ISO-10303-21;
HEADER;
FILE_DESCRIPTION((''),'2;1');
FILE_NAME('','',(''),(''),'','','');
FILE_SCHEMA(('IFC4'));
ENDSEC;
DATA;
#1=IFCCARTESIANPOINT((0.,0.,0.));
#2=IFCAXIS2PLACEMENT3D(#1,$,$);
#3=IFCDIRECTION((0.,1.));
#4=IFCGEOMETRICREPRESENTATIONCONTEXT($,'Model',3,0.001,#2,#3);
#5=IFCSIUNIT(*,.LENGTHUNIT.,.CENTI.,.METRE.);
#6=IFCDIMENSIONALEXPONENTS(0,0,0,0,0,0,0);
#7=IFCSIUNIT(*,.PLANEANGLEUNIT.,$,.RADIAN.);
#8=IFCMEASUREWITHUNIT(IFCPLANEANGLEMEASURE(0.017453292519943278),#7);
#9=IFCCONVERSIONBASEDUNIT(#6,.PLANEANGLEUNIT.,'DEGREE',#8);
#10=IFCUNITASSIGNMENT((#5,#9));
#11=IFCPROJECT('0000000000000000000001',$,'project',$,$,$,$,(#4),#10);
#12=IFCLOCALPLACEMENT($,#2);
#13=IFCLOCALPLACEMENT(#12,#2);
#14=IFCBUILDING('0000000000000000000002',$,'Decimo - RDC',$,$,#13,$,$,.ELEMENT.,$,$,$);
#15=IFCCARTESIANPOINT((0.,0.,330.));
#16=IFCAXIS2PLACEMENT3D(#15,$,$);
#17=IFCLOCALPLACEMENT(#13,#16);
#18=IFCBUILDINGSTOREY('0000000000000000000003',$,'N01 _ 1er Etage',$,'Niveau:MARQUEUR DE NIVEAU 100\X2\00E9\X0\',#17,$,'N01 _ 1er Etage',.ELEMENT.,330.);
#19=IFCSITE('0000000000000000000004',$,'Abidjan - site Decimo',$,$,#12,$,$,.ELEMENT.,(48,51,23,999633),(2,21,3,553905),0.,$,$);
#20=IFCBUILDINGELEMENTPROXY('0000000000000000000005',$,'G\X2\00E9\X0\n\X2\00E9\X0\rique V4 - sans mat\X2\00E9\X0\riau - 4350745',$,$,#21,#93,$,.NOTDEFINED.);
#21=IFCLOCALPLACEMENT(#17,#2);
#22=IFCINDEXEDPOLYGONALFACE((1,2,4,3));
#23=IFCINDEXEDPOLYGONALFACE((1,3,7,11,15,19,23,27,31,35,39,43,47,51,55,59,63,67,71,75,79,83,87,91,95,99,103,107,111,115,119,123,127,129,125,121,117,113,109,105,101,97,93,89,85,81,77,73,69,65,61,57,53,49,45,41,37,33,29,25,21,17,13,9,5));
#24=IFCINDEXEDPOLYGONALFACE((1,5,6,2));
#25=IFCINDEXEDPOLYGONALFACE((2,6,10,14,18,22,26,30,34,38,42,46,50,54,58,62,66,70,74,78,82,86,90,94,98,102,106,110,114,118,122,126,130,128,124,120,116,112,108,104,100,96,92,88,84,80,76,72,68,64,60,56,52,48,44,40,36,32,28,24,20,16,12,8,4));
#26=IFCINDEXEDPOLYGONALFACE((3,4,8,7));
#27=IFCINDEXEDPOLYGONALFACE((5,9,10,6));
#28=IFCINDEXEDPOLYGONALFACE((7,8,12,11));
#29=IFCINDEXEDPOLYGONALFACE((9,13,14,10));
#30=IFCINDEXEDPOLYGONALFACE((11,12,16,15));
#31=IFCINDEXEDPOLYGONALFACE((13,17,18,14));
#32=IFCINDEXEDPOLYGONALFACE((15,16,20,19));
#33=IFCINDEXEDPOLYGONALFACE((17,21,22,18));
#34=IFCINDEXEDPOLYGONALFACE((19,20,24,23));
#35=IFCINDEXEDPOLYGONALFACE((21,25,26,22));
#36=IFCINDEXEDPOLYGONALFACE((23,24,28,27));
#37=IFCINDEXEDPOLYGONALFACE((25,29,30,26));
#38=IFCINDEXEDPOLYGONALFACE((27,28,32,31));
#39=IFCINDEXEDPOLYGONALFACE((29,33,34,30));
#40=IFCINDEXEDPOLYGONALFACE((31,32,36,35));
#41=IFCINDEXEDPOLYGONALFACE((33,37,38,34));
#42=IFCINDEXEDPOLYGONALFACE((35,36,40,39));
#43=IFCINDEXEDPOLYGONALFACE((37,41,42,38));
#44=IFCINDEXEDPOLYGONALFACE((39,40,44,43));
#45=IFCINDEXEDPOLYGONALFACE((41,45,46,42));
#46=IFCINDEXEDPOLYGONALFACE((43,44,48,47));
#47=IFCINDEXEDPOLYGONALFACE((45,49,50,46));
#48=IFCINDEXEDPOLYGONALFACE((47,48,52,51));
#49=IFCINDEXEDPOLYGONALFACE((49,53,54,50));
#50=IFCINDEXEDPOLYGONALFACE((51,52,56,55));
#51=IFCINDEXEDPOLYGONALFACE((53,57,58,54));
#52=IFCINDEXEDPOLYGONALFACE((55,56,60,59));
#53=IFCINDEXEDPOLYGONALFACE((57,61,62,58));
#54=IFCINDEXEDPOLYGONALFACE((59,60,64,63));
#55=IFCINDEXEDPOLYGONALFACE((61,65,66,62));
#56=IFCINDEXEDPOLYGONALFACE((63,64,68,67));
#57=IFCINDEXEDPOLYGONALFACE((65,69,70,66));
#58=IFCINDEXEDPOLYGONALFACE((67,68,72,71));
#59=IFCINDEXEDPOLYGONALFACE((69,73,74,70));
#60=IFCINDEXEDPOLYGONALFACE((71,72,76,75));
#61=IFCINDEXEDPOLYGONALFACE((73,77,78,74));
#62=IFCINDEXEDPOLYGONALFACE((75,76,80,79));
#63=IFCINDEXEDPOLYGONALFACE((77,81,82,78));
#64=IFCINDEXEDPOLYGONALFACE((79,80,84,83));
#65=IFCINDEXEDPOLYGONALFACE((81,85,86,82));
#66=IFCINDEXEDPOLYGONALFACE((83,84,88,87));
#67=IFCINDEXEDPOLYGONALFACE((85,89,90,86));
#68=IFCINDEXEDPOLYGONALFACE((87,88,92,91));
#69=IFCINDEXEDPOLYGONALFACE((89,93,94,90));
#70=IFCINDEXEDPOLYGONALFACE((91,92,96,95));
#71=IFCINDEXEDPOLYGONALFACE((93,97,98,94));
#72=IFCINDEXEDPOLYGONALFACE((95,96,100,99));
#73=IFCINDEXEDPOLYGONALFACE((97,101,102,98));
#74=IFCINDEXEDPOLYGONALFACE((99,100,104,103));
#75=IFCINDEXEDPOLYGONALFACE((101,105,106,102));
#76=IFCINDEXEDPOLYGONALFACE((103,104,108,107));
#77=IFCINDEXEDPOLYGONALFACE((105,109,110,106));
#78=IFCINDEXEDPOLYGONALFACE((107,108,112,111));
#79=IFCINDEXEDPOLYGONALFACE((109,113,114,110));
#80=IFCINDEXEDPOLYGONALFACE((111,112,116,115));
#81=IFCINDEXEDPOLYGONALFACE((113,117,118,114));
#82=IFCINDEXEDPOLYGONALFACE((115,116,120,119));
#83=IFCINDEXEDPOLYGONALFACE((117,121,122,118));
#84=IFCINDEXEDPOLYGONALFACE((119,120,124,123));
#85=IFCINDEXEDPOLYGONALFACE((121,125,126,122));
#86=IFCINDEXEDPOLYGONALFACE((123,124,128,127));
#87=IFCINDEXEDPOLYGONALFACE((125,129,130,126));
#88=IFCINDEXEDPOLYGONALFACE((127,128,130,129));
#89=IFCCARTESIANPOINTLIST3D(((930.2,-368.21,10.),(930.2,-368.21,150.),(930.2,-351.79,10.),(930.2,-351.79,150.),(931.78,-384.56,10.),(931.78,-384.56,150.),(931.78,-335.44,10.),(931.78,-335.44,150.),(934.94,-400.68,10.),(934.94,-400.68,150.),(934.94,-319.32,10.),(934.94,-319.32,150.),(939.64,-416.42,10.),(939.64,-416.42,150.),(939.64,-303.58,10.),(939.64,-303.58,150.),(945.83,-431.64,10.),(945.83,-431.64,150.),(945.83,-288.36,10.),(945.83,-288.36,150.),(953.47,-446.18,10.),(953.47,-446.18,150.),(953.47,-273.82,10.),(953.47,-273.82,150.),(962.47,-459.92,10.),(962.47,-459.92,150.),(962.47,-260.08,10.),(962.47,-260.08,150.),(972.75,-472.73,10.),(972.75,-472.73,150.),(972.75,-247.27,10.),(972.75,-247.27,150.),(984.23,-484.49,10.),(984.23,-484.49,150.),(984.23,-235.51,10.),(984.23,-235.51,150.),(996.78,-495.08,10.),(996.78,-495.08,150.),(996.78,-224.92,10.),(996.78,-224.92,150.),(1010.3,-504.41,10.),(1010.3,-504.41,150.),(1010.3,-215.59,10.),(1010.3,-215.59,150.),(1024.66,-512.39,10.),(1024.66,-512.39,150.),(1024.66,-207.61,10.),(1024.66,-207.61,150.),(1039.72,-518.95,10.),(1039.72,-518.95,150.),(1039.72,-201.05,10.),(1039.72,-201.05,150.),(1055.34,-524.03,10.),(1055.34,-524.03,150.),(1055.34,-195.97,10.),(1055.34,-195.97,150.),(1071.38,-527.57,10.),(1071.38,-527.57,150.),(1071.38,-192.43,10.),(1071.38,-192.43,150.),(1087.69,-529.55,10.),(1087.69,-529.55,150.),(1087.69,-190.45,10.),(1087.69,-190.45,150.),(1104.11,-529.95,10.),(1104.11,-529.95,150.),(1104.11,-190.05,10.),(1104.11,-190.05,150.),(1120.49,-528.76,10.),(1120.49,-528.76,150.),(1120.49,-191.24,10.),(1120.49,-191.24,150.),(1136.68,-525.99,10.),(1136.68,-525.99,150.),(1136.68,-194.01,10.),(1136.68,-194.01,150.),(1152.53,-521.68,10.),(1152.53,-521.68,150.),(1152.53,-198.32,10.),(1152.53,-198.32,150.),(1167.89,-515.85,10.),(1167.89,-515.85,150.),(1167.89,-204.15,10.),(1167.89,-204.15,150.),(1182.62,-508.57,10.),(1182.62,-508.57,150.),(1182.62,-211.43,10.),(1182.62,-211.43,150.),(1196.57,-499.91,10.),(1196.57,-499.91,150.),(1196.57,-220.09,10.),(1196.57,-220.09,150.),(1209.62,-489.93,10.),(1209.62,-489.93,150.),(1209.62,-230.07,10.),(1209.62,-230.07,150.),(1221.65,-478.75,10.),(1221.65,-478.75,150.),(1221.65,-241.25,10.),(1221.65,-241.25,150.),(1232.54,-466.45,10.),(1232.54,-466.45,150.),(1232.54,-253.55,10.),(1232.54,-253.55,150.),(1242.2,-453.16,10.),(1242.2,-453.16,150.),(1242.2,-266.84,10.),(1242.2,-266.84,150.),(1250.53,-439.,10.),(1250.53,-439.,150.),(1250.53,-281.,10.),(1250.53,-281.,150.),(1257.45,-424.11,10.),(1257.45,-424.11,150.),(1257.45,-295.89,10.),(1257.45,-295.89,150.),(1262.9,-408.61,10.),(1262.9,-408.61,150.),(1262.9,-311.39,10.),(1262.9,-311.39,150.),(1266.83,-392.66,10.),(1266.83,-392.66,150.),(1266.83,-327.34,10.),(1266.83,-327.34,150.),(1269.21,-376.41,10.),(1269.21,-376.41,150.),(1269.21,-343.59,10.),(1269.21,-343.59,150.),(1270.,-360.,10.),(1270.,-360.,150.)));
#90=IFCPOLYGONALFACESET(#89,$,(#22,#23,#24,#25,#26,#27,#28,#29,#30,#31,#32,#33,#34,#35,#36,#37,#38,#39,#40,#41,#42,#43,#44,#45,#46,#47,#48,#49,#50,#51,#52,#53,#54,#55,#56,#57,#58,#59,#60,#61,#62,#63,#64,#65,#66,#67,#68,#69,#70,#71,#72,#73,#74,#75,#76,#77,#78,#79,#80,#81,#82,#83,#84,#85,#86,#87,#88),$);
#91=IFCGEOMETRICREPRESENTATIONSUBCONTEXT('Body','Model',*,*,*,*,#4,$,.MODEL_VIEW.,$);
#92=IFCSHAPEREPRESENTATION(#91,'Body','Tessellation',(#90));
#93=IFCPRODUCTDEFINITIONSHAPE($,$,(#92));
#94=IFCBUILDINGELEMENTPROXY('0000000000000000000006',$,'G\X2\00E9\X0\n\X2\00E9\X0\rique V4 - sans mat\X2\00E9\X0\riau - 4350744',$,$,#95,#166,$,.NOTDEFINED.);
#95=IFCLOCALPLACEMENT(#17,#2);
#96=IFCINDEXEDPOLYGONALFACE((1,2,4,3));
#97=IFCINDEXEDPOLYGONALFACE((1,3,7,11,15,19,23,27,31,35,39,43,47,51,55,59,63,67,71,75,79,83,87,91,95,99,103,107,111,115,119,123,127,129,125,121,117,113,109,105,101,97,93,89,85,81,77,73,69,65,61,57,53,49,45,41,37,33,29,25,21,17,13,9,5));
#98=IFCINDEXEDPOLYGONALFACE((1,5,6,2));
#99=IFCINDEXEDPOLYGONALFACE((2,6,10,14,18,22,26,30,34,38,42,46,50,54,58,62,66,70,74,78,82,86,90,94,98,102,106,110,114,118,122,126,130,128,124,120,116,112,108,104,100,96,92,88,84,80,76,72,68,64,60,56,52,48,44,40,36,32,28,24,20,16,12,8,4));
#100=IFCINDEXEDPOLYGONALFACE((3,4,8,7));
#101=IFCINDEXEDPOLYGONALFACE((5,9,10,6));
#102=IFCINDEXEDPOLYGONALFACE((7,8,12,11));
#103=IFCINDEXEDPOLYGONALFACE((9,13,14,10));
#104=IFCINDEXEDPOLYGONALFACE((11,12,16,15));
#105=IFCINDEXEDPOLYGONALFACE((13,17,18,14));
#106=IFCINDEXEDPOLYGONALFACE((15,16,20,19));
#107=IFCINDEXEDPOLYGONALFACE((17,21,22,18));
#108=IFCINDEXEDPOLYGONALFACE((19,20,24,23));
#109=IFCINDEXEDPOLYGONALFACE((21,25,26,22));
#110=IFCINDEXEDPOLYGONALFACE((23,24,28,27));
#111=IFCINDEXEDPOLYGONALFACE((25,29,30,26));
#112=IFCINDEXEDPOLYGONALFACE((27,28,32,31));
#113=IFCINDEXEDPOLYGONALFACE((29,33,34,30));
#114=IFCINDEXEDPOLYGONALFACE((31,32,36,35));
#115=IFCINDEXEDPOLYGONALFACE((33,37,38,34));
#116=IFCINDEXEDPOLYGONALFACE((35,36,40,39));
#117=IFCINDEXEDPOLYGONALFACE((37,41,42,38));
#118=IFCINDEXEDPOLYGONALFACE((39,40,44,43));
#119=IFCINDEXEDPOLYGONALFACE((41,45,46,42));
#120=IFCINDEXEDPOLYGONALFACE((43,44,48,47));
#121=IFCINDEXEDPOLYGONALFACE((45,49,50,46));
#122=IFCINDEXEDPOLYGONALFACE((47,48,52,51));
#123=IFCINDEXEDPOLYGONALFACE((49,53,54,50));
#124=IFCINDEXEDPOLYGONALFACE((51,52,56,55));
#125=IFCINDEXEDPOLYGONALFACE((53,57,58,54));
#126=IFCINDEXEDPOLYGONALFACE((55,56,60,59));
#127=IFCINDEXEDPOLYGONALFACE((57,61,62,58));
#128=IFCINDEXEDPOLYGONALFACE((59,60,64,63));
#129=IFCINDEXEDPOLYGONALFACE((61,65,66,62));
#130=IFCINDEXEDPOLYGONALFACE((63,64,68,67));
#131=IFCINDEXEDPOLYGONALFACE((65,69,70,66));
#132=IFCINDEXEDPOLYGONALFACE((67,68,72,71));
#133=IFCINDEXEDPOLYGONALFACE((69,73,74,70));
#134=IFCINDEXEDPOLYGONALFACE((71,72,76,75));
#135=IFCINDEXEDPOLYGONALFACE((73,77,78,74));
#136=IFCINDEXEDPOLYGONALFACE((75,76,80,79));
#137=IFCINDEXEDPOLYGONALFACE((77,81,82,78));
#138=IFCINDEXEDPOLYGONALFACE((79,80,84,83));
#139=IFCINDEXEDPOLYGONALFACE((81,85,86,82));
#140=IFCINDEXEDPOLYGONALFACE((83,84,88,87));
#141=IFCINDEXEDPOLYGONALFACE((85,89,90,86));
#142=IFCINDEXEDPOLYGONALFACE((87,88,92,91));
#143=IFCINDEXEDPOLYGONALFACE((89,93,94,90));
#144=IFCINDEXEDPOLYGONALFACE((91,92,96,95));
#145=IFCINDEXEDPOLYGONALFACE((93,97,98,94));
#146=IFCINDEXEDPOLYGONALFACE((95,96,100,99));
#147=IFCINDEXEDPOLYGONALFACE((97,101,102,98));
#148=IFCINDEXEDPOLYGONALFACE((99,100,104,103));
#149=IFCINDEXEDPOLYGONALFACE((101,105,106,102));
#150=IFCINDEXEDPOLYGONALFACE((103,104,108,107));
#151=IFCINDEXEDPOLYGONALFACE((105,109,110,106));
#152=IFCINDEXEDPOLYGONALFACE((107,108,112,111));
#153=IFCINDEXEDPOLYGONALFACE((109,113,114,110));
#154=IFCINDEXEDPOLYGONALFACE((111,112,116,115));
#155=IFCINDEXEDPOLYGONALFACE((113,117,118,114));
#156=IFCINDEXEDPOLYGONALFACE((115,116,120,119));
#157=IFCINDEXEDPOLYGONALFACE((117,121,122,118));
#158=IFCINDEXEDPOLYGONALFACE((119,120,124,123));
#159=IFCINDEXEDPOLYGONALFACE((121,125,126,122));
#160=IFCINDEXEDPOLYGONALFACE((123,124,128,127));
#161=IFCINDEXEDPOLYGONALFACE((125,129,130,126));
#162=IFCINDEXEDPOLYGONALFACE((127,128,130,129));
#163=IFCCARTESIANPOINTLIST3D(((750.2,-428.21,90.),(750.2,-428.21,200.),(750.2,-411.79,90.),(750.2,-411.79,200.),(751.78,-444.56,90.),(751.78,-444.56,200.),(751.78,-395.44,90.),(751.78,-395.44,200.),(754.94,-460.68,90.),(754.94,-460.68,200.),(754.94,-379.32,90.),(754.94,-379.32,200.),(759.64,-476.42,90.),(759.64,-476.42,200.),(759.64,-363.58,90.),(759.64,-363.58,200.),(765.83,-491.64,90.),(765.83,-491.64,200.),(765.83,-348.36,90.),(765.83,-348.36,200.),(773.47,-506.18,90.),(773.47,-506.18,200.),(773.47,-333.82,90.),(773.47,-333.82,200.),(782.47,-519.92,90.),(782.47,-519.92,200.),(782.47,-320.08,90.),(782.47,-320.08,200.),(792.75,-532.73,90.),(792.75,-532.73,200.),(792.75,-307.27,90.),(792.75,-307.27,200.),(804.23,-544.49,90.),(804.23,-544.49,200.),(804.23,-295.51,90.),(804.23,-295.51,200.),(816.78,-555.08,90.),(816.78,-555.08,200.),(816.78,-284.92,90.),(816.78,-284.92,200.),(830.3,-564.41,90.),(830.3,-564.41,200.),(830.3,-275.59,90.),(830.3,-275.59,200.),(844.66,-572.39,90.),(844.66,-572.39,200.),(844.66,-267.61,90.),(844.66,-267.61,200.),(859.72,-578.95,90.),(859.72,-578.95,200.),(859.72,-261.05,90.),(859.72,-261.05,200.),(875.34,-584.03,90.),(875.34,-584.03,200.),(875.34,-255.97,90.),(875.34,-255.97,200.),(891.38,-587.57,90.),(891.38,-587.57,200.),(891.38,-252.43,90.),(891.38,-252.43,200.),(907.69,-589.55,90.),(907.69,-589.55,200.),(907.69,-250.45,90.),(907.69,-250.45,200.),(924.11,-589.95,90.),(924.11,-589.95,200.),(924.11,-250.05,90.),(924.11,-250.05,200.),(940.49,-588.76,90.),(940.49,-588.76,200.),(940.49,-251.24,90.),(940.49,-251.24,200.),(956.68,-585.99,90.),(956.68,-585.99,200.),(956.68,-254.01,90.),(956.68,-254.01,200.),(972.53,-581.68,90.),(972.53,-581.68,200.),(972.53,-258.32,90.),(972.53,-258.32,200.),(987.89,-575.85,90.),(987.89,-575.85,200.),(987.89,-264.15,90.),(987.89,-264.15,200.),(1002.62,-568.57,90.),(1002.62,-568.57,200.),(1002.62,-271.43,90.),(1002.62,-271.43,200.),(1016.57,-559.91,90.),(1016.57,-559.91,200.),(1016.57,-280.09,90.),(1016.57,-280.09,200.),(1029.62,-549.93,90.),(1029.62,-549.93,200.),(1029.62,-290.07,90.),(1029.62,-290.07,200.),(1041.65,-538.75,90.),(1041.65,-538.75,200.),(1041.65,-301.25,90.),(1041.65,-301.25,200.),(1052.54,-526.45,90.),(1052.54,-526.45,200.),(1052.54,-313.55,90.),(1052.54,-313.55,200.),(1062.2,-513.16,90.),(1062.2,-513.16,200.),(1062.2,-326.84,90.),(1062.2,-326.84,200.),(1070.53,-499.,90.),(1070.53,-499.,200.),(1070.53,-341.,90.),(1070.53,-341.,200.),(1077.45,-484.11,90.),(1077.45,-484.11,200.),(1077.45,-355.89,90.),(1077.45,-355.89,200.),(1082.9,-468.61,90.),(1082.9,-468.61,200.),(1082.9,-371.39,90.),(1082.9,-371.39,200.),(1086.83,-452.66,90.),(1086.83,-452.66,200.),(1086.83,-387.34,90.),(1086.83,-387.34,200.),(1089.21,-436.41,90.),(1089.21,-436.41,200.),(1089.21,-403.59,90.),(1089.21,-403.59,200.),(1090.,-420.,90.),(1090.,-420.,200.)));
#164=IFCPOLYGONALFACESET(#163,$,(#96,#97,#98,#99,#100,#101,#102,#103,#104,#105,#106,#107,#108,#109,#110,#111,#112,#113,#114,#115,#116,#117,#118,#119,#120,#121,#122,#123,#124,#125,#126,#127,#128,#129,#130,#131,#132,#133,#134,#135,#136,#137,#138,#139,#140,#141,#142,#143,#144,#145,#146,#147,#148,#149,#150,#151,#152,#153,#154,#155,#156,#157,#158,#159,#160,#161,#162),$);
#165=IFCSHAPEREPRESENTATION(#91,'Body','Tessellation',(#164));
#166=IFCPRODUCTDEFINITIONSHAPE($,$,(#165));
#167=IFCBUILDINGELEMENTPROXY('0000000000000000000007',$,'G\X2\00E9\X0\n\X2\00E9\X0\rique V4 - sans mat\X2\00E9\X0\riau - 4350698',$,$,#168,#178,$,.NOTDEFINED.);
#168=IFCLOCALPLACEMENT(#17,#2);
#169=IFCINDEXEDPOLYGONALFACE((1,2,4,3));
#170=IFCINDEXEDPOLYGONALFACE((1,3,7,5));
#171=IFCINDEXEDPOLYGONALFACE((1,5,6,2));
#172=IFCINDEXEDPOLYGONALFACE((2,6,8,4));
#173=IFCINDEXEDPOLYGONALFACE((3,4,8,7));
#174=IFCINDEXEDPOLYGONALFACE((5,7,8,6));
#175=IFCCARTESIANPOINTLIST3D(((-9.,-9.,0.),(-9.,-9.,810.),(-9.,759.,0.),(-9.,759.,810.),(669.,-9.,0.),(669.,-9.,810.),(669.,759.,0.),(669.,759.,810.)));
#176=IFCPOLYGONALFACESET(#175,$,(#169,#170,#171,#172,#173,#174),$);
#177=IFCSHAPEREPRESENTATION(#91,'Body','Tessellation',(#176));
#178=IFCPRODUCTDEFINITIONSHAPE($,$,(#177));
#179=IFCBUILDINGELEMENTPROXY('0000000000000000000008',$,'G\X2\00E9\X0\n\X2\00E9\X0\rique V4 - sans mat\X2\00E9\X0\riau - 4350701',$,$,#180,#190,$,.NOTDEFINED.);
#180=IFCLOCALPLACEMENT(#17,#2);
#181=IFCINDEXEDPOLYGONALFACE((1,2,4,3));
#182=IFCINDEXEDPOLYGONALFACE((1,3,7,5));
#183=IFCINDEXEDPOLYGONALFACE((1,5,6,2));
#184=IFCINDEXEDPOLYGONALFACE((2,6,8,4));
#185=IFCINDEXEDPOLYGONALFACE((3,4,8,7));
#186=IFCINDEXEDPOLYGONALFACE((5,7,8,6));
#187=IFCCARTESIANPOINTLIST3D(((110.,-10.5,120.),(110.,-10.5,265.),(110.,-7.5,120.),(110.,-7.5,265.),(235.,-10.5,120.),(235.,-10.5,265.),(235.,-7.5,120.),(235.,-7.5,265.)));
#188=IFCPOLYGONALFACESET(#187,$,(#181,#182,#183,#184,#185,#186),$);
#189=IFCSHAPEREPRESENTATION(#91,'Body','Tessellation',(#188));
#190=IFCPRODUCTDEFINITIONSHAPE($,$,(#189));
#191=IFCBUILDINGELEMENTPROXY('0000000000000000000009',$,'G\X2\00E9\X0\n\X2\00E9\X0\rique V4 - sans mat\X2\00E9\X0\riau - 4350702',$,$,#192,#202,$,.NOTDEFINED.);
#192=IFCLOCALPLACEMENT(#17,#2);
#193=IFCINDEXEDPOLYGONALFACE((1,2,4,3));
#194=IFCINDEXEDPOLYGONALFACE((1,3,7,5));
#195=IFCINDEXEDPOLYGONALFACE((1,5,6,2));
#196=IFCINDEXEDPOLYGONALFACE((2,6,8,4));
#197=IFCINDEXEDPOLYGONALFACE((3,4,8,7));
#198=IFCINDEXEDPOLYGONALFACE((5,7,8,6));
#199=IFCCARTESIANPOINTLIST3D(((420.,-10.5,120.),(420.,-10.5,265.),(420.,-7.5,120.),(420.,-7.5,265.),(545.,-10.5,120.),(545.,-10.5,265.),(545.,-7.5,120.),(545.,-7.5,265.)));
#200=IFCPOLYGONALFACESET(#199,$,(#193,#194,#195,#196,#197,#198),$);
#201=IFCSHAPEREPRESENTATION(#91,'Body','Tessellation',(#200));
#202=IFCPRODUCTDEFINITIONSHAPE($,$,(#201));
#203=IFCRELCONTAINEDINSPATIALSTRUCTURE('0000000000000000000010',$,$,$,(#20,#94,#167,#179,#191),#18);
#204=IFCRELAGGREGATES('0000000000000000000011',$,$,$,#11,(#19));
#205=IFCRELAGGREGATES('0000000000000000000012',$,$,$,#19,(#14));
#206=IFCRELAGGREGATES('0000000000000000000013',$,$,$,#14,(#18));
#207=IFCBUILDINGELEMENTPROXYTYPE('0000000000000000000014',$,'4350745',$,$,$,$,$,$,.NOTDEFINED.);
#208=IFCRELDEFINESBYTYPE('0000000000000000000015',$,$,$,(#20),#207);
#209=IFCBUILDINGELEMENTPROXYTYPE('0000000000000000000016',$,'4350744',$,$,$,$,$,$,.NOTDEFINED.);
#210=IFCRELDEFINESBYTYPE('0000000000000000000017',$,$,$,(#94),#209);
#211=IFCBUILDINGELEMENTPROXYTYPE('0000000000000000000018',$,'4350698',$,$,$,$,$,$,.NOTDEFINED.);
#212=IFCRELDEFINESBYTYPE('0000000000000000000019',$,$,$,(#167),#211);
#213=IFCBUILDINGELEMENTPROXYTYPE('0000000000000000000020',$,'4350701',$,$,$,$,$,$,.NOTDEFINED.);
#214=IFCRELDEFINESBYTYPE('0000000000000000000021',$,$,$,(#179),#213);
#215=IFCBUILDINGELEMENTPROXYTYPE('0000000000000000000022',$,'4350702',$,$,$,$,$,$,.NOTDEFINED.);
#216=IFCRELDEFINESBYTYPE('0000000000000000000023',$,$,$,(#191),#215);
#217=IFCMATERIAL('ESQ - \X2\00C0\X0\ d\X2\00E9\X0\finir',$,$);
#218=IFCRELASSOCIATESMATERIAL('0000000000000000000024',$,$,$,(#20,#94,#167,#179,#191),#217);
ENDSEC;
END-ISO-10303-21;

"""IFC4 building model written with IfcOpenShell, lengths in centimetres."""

from ifc_helpers import new_model, entity, si_unit, converted_unit, direction, frame, frame_2d, origin, origin_2d_with_axis, place, context, subcontext, project, spatial, rectangle, circle, extrude, material, type_object, element, save


model = new_model("IFC4")

# Units and contexts
model_context = context("Model", 3, precision=0.001, world=origin(), true_north=direction((0.0, 1.0)))
body_context = subcontext(model_context, "Body", "Model", "MODEL_VIEW")
ifc_project = project(units=[si_unit("LENGTHUNIT", "METRE", prefix="CENTI"), converted_unit("PLANEANGLEUNIT", "DEGREE", entity("IfcPlaneAngleMeasure", 0.017453292519943278), si_unit("PLANEANGLEUNIT", "RADIAN"), dimensions=[0, 0, 0, 0, 0, 0, 0])], contexts=[model_context])

# Site, building, storey
site_placement = place(None, origin())
site = spatial("IfcSite", under=ifc_project, at=site_placement, Name="Abidjan - site Decimo", CompositionType="ELEMENT", RefLatitude=(48, 51, 23, 999633), RefLongitude=(2, 21, 3, 553905), RefElevation=0.0)
building_placement = place(site_placement, origin())
building = spatial("IfcBuilding", under=site, at=building_placement, Name="Decimo - RDC", CompositionType="ELEMENT")
storey_placement = place(building_placement, frame((0.0, 0.0, 330.0)))
storey = spatial("IfcBuildingStorey", under=building, at=storey_placement, Name="N01 _ 1er Etage", ObjectType="Niveau:MARQUEUR DE NIVEAU 100é", LongName="N01 _ 1er Etage", CompositionType="ELEMENT", Elevation=330.0)

# Building element proxies
ifc_material = material(Name="ESQ - À définir")
building_element_proxy_type_1 = type_object("IfcBuildingElementProxyType", Name="4350745", PredefinedType="NOTDEFINED")
proxy_1_placement = place(storey_placement, origin())
element("IfcBuildingElementProxy", 1, at=proxy_1_placement, inside=storey, type_object=building_element_proxy_type_1, material=ifc_material, Name="Générique V4 - sans matériau - 4350745", PredefinedType="NOTDEFINED", context=body_context, shape_type="SweptSolid", body=[
    extrude(circle(Radius=170.0, at=origin_2d_with_axis()), frame((1100.0, -360.0, 10.0)), (0.0, 0.0, 1.0), 140.0),
])
building_element_proxy_type_2 = type_object("IfcBuildingElementProxyType", Name="4350744", PredefinedType="NOTDEFINED")
proxy_2_placement = place(storey_placement, origin())
element("IfcBuildingElementProxy", 2, at=proxy_2_placement, inside=storey, type_object=building_element_proxy_type_2, material=ifc_material, Name="Générique V4 - sans matériau - 4350744", PredefinedType="NOTDEFINED", context=body_context, shape_type="SweptSolid", body=[
    extrude(circle(Radius=170.0, at=origin_2d_with_axis()), frame((920.0, -420.0, 90.0)), (0.0, 0.0, 1.0), 110.0),
])
building_element_proxy_type_3 = type_object("IfcBuildingElementProxyType", Name="4350698", PredefinedType="NOTDEFINED")
proxy_3_placement = place(storey_placement, origin())
element("IfcBuildingElementProxy", 3, at=proxy_3_placement, inside=storey, type_object=building_element_proxy_type_3, material=ifc_material, Name="Générique V4 - sans matériau - 4350698", PredefinedType="NOTDEFINED", context=body_context, shape_type="SweptSolid", body=[
    extrude(rectangle(XDim=678.0, YDim=768.0, at=origin_2d_with_axis()), frame((330.0, 375.0, 0.0)), (0.0, 0.0, 1.0), 810.0),
])
building_element_proxy_type_4 = type_object("IfcBuildingElementProxyType", Name="4350701", PredefinedType="NOTDEFINED")
proxy_4_placement = place(storey_placement, origin())
element("IfcBuildingElementProxy", 4, at=proxy_4_placement, inside=storey, type_object=building_element_proxy_type_4, material=ifc_material, Name="Générique V4 - sans matériau - 4350701", PredefinedType="NOTDEFINED", context=body_context, shape_type="SweptSolid", body=[
    extrude(rectangle(XDim=125.0, YDim=3.0, at=frame_2d((0.0, 0.0), x_axis=(1.0, 0.0))), frame((172.5, -9.0, 120.0)), (0.0, 0.0, 1.0), 145.0),
])
building_element_proxy_type_5 = type_object("IfcBuildingElementProxyType", Name="4350702", PredefinedType="NOTDEFINED")
proxy_5_placement = place(storey_placement, origin())
element("IfcBuildingElementProxy", 5, at=proxy_5_placement, inside=storey, type_object=building_element_proxy_type_5, material=ifc_material, Name="Générique V4 - sans matériau - 4350702", PredefinedType="NOTDEFINED", context=body_context, shape_type="SweptSolid", body=[
    extrude(rectangle(XDim=125.0, YDim=3.0, at=frame_2d((0.0, 0.0), x_axis=(1.0, 0.0))), frame((482.5, -9.0, 120.0)), (0.0, 0.0, 1.0), 145.0),
])

save(model, "model.ifc")
